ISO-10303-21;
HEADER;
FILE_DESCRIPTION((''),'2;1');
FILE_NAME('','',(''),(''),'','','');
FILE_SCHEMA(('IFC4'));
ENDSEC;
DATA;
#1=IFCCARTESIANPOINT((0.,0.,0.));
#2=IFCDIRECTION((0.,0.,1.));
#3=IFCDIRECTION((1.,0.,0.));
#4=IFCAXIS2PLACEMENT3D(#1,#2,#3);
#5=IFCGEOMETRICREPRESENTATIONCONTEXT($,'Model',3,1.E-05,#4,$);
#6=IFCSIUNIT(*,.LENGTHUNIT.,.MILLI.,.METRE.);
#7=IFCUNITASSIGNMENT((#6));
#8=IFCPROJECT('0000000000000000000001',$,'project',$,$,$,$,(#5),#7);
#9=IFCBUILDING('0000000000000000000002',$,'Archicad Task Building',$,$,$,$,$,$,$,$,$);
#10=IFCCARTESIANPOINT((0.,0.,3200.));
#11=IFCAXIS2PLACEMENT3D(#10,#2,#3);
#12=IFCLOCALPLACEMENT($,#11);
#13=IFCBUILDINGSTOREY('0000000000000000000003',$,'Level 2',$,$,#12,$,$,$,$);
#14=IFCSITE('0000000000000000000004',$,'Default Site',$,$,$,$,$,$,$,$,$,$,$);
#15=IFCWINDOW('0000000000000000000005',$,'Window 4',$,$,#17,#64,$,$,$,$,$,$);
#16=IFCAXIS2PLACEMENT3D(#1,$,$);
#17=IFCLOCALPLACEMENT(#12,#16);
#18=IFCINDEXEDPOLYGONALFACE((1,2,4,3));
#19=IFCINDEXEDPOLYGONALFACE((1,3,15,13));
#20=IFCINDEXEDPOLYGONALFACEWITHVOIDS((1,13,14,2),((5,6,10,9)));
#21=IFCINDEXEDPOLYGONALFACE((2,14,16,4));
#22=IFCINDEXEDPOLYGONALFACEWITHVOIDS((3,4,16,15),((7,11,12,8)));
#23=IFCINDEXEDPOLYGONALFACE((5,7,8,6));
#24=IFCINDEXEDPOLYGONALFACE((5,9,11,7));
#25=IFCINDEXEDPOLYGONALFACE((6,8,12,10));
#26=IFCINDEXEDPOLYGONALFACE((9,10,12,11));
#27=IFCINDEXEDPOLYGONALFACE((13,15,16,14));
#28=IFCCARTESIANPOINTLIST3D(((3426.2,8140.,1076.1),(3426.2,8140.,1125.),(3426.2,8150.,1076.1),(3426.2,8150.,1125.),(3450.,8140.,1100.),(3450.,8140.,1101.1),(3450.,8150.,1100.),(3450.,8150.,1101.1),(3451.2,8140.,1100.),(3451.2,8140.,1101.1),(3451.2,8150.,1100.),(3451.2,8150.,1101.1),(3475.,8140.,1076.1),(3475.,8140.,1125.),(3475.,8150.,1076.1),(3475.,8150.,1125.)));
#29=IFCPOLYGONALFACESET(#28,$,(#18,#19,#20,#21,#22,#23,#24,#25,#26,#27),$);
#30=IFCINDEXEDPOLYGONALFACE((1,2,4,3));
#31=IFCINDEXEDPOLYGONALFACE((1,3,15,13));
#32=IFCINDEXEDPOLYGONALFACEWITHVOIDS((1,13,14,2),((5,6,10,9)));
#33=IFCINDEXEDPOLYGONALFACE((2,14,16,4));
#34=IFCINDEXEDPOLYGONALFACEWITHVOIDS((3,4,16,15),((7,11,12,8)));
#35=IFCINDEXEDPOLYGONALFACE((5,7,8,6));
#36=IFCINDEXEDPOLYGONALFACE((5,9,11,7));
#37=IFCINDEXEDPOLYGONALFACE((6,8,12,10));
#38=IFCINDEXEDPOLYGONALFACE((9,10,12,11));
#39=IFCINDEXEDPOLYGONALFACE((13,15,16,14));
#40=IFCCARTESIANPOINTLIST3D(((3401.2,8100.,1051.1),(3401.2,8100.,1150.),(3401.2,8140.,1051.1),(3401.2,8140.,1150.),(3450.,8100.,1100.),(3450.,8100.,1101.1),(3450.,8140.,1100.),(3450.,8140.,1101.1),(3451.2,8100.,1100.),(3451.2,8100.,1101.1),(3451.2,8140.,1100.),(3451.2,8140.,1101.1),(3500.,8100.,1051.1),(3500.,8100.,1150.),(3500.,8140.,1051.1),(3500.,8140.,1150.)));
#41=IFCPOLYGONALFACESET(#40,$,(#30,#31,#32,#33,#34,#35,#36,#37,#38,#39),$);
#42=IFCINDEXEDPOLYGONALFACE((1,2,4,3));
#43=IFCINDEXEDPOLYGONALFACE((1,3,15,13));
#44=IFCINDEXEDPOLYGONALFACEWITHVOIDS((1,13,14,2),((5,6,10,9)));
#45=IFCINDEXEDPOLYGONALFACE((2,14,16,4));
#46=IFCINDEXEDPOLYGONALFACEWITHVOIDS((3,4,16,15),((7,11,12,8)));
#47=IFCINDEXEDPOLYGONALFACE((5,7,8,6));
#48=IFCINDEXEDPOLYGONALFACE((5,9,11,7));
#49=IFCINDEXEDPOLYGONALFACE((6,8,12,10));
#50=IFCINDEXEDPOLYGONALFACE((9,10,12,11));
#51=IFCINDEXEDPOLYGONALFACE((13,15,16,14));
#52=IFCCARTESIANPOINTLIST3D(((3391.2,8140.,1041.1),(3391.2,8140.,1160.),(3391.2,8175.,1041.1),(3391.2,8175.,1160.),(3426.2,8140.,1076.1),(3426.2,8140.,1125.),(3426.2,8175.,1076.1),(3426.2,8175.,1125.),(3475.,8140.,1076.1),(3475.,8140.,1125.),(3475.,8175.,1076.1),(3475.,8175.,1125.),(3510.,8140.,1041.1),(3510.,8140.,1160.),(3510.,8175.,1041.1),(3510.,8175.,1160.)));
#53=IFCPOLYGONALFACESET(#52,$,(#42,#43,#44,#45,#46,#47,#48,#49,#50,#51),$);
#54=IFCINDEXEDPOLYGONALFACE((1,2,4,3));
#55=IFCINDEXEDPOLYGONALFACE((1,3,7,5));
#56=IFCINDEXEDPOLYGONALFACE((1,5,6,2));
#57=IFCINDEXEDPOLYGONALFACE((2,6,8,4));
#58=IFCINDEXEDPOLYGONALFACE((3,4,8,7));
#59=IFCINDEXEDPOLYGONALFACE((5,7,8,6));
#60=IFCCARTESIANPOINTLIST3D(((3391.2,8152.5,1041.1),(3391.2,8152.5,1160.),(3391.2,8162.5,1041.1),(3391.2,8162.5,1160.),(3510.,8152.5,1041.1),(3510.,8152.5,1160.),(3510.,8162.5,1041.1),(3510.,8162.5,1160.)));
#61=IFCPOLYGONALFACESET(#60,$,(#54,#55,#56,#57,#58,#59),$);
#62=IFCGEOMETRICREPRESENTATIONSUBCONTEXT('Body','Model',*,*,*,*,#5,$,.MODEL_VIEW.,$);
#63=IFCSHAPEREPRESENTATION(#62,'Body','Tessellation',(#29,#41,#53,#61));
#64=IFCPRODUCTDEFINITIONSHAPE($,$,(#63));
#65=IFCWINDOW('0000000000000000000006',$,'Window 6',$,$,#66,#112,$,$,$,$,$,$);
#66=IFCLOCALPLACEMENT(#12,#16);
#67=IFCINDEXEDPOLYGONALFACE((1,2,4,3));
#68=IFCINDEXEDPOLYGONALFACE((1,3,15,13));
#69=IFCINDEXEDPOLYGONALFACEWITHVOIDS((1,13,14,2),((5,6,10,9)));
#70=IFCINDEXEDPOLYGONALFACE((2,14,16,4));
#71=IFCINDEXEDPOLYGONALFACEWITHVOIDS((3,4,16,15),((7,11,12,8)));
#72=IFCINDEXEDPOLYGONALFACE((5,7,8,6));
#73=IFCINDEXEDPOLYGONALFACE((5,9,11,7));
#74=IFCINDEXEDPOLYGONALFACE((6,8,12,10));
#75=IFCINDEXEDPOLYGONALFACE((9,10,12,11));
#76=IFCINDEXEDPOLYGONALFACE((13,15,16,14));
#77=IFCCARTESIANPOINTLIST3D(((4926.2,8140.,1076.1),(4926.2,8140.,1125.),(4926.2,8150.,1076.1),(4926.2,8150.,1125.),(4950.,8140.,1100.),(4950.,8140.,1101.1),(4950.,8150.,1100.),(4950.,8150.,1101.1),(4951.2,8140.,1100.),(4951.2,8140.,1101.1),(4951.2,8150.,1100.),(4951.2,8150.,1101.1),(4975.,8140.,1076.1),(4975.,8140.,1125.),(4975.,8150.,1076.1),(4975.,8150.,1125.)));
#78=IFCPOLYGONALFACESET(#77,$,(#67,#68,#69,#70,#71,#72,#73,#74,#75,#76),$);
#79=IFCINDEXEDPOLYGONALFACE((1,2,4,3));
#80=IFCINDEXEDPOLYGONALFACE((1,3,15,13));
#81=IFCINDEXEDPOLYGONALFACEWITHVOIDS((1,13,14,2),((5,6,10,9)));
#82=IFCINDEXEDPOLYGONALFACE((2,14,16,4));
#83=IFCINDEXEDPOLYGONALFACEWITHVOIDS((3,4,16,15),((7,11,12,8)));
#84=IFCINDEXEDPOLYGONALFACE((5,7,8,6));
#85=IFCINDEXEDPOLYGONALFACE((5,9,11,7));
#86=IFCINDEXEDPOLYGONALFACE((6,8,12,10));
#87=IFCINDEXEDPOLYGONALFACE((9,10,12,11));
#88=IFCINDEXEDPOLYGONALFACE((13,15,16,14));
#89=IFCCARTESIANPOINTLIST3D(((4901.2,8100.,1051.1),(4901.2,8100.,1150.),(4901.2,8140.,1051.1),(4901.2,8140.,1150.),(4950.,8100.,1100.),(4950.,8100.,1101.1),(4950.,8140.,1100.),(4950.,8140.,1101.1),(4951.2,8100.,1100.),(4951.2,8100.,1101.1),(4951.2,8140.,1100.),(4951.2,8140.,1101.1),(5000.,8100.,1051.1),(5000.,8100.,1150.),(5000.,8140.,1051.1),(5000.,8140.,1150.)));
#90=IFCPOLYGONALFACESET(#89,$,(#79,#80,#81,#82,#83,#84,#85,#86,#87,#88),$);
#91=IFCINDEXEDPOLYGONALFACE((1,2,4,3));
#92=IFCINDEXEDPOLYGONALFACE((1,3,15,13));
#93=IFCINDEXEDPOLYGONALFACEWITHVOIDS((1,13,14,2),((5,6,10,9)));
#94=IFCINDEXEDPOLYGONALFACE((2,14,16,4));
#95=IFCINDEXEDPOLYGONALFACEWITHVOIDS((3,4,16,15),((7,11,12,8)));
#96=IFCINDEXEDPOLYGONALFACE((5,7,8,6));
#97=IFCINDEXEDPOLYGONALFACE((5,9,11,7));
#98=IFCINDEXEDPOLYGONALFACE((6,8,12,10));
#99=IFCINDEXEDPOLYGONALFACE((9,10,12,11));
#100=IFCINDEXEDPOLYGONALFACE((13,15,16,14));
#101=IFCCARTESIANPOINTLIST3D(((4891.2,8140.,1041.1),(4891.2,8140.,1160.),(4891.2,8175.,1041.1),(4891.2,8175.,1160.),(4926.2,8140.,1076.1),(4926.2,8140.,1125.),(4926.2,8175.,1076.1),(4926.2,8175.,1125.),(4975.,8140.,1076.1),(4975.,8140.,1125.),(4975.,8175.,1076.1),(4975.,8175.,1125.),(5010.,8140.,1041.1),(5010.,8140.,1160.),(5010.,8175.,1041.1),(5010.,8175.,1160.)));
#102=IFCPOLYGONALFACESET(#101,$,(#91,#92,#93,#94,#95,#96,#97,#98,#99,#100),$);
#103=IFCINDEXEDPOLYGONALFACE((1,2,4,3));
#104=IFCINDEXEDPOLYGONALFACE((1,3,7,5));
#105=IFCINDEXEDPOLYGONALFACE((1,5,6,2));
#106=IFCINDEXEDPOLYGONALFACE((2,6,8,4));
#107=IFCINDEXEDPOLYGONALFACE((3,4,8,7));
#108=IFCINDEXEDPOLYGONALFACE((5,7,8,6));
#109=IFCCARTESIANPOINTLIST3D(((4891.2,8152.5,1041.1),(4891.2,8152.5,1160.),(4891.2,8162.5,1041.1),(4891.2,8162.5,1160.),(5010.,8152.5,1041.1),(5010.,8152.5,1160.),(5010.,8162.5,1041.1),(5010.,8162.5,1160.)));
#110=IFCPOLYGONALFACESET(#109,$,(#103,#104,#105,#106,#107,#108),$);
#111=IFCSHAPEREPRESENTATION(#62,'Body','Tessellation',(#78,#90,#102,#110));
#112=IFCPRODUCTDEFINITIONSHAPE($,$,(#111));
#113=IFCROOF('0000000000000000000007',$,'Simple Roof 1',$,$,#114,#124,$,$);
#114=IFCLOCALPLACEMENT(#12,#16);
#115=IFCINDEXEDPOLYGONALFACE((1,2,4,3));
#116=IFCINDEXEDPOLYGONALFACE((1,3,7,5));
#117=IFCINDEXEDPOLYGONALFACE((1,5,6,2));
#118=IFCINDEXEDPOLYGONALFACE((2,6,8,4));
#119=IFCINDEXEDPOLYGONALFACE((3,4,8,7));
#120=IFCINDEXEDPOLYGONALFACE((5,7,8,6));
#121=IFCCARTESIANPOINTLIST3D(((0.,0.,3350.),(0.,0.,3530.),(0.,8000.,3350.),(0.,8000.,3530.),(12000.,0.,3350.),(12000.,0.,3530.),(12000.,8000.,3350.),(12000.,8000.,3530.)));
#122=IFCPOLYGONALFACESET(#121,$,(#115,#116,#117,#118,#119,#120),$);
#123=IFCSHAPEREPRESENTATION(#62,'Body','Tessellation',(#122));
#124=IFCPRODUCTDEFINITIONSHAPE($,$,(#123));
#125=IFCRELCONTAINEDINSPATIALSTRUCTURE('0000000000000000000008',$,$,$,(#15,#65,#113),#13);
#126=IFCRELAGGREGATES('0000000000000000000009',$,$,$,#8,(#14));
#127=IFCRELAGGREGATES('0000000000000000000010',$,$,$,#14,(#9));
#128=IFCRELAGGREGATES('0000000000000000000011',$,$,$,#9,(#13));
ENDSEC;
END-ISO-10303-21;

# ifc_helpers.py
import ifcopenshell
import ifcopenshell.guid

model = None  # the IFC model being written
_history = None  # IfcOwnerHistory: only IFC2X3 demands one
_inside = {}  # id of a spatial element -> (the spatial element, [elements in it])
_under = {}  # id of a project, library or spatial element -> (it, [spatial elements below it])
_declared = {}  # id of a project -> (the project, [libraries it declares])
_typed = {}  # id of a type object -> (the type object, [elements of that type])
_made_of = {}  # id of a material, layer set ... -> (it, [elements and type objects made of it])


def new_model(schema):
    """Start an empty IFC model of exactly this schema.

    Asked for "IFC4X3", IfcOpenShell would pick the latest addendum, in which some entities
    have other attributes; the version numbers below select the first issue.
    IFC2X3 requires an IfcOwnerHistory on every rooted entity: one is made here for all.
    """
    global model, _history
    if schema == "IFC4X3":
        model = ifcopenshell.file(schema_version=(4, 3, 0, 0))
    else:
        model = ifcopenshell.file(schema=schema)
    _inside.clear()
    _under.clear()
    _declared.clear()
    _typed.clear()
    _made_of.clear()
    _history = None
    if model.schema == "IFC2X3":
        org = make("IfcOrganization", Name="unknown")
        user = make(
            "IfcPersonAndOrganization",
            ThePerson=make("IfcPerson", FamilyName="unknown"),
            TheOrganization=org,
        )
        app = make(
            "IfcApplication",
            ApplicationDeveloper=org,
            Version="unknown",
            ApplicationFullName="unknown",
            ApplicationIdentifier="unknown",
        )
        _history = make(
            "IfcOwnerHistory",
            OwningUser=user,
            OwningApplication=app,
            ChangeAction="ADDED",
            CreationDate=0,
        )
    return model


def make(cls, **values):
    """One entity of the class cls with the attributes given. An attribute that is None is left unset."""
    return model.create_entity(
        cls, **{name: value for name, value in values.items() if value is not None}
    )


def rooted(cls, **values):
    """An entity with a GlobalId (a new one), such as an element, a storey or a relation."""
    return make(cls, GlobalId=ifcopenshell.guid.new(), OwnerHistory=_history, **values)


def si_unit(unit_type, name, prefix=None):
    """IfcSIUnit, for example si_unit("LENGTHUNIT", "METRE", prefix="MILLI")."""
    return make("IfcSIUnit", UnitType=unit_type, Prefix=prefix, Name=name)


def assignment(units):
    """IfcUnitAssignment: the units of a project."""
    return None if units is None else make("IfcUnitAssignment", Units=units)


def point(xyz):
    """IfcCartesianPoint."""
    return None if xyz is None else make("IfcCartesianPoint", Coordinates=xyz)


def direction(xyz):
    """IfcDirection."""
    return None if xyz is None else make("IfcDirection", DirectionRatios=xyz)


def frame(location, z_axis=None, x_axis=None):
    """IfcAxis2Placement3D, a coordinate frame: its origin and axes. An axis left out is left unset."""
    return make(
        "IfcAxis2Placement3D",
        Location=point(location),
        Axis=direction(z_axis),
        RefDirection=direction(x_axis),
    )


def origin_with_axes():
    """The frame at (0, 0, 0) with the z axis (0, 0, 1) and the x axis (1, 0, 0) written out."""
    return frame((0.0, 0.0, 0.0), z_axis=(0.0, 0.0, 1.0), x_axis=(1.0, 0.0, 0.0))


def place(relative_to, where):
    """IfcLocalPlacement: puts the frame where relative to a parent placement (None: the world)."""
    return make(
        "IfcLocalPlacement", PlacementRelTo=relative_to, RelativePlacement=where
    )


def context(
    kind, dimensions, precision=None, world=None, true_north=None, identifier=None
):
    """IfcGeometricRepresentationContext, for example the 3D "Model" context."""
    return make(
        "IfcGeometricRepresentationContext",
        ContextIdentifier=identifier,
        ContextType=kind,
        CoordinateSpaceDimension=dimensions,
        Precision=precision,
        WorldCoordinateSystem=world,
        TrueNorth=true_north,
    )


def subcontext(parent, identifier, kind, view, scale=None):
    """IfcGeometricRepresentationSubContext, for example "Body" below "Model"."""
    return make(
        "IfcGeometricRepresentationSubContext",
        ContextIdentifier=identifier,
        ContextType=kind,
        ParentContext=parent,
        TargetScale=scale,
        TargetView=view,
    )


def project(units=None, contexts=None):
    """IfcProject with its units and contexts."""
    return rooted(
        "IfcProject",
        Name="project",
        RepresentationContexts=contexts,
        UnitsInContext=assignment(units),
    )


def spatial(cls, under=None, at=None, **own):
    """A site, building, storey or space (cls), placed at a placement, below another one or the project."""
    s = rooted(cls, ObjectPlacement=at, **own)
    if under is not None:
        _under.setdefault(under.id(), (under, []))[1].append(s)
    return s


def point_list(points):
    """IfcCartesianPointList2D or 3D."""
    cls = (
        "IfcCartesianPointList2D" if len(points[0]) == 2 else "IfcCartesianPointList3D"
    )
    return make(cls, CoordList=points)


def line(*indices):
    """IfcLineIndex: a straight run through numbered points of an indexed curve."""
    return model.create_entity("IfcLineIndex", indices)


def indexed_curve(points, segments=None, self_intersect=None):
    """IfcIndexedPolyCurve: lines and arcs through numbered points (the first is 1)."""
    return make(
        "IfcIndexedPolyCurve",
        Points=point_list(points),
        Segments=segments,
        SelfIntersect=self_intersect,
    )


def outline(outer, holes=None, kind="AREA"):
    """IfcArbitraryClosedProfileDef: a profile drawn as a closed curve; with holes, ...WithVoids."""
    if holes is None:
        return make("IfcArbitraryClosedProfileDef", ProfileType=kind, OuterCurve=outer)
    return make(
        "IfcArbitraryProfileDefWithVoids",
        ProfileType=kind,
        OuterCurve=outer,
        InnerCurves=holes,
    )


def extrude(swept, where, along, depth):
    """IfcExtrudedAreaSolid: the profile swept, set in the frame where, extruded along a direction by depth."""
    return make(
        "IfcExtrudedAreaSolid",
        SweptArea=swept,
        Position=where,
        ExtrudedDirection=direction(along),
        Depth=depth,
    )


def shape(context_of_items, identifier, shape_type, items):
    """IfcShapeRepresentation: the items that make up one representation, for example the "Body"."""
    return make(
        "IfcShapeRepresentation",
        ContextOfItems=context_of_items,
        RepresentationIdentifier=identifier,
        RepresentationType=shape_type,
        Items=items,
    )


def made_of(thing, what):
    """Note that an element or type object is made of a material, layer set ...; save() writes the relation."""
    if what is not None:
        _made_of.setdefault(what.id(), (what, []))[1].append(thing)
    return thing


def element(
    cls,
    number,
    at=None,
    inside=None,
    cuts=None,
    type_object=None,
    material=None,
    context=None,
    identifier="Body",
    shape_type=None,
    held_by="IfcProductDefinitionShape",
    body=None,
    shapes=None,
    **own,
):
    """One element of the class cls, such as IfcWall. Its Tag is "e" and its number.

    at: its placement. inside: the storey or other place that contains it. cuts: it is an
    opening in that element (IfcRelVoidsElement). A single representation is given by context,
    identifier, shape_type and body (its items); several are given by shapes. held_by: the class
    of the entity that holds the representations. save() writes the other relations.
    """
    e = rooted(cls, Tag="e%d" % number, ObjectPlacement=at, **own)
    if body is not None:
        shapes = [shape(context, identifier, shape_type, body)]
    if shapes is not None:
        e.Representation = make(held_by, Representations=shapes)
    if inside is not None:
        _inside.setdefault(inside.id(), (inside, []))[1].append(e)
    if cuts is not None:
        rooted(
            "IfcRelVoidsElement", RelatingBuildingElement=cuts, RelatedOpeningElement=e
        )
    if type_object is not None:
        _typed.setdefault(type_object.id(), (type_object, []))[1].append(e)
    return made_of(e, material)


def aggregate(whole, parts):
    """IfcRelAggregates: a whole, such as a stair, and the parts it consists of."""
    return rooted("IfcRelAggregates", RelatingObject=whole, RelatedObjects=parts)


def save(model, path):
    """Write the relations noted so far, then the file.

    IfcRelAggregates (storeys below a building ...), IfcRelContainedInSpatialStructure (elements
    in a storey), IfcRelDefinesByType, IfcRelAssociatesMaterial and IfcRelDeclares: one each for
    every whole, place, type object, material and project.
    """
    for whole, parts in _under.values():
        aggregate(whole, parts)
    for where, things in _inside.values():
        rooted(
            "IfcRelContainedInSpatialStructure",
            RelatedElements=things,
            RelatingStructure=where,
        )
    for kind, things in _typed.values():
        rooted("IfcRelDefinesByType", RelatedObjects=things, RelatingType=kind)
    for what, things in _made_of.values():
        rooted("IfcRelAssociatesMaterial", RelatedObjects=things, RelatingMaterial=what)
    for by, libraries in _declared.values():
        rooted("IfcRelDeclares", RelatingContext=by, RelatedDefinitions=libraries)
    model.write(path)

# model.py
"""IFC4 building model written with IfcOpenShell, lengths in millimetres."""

from ifc_helpers import new_model, si_unit, frame, origin_with_axes, place, context, subcontext, project, spatial, line, indexed_curve, outline, extrude, element, save


model = new_model("IFC4")

# Units and contexts
model_context = context("Model", 3, precision=1e-05, world=origin_with_axes())
body_context = subcontext(model_context, "Body", "Model", "MODEL_VIEW")
ifc_project = project(units=[si_unit("LENGTHUNIT", "METRE", prefix="MILLI")], contexts=[model_context])

# Site, building, storey
site = spatial("IfcSite", under=ifc_project, Name="Default Site")
building = spatial("IfcBuilding", under=site, Name="Archicad Task Building")
storey_placement = place(None, frame((0.0, 0.0, 3200.0), z_axis=(0.0, 0.0, 1.0), x_axis=(1.0, 0.0, 0.0)))
storey = spatial("IfcBuildingStorey", under=building, at=storey_placement, Name="Level 2")

# Windows
for number, where, z_axis, x_axis, name in (
    (1, (3450.0, 8050.0, 1100.0), (0.0, 0.0, 1.0), (1.0, 0.0, 0.0), "Window 4"),
    (2, (4950.0, 8050.0, 1100.0), (0.0, 0.0, 1.0), (1.0, 0.0, 0.0), "Window 6"),
):
    element("IfcWindow", number, at=place(storey_placement, frame(where, z_axis=z_axis, x_axis=x_axis)), inside=storey, Name=name, context=body_context, shape_type="SweptSolid", body=[
        extrude(outline(indexed_curve([(0.0, 0.0), (1.2, 0.0), (1.2, 1.1), (0.0, 1.1)], segments=[line(1, 2, 3, 4, 1)]), holes=[indexed_curve([(25.0, 25.0), (-23.8, 25.0), (-23.8, -23.9), (25.0, -23.9)], segments=[line(1, 2, 3, 4, 1)])]), frame((0.0, 90.0, 0.0), z_axis=(0.0, -1.0, 0.0), x_axis=(1.0, 0.0, 0.0)), (0.0, 0.0, -1.0), 10.0),
        extrude(outline(indexed_curve([(0.0, 0.0), (1.2, 0.0), (1.2, 1.1), (0.0, 1.1)], segments=[line(1, 2, 3, 4, 1)]), holes=[indexed_curve([(50.0, 50.0), (-48.8, 50.0), (-48.8, -48.9), (50.0, -48.9)], segments=[line(1, 2, 3, 4, 1)])]), frame((0.0, 50.0, 0.0), z_axis=(0.0, -1.0, 0.0), x_axis=(1.0, 0.0, 0.0)), (0.0, 0.0, -1.0), 40.0),
        extrude(outline(indexed_curve([(0.0, 0.0), (-48.8, 0.0), (-48.8, -48.9), (0.0, -48.9)], segments=[line(1, 2, 3, 4, 1)]), holes=[indexed_curve([(35.0, 35.0), (-83.8, 35.0), (-83.8, -83.9), (35.0, -83.9)], segments=[line(1, 2, 3, 4, 1)])]), frame((25.0, 90.0, 25.0), z_axis=(0.0, -1.0, 0.0), x_axis=(1.0, 0.0, 0.0)), (0.0, 0.0, -1.0), 35.0),
        extrude(outline(indexed_curve([(35.0, 35.0), (-83.8, 35.0), (-83.8, -83.9), (35.0, -83.9)], segments=[line(1, 2, 3, 4, 1)])), frame((25.0, 102.5, 25.0), z_axis=(0.0, -1.0, 0.0), x_axis=(1.0, 0.0, 0.0)), (0.0, 0.0, -1.0), 10.0),
    ])

# Roof
roof_placement = place(storey_placement, frame((0.0, 0.0, 3350.0), z_axis=(0.0, 0.0, 1.0), x_axis=(1.0, 0.0, 0.0)))
element("IfcRoof", 3, at=roof_placement, inside=storey, Name="Simple Roof 1", context=body_context, shape_type="SweptSolid", body=[
    extrude(outline(indexed_curve([(0.0, 0.0), (12000.0, 0.0), (12000.0, 8000.0), (0.0, 8000.0), (0.0, 0.0)])), None, (0.0, 0.0, 1.0), 180.0),
])

save(model, "model.ifc")
